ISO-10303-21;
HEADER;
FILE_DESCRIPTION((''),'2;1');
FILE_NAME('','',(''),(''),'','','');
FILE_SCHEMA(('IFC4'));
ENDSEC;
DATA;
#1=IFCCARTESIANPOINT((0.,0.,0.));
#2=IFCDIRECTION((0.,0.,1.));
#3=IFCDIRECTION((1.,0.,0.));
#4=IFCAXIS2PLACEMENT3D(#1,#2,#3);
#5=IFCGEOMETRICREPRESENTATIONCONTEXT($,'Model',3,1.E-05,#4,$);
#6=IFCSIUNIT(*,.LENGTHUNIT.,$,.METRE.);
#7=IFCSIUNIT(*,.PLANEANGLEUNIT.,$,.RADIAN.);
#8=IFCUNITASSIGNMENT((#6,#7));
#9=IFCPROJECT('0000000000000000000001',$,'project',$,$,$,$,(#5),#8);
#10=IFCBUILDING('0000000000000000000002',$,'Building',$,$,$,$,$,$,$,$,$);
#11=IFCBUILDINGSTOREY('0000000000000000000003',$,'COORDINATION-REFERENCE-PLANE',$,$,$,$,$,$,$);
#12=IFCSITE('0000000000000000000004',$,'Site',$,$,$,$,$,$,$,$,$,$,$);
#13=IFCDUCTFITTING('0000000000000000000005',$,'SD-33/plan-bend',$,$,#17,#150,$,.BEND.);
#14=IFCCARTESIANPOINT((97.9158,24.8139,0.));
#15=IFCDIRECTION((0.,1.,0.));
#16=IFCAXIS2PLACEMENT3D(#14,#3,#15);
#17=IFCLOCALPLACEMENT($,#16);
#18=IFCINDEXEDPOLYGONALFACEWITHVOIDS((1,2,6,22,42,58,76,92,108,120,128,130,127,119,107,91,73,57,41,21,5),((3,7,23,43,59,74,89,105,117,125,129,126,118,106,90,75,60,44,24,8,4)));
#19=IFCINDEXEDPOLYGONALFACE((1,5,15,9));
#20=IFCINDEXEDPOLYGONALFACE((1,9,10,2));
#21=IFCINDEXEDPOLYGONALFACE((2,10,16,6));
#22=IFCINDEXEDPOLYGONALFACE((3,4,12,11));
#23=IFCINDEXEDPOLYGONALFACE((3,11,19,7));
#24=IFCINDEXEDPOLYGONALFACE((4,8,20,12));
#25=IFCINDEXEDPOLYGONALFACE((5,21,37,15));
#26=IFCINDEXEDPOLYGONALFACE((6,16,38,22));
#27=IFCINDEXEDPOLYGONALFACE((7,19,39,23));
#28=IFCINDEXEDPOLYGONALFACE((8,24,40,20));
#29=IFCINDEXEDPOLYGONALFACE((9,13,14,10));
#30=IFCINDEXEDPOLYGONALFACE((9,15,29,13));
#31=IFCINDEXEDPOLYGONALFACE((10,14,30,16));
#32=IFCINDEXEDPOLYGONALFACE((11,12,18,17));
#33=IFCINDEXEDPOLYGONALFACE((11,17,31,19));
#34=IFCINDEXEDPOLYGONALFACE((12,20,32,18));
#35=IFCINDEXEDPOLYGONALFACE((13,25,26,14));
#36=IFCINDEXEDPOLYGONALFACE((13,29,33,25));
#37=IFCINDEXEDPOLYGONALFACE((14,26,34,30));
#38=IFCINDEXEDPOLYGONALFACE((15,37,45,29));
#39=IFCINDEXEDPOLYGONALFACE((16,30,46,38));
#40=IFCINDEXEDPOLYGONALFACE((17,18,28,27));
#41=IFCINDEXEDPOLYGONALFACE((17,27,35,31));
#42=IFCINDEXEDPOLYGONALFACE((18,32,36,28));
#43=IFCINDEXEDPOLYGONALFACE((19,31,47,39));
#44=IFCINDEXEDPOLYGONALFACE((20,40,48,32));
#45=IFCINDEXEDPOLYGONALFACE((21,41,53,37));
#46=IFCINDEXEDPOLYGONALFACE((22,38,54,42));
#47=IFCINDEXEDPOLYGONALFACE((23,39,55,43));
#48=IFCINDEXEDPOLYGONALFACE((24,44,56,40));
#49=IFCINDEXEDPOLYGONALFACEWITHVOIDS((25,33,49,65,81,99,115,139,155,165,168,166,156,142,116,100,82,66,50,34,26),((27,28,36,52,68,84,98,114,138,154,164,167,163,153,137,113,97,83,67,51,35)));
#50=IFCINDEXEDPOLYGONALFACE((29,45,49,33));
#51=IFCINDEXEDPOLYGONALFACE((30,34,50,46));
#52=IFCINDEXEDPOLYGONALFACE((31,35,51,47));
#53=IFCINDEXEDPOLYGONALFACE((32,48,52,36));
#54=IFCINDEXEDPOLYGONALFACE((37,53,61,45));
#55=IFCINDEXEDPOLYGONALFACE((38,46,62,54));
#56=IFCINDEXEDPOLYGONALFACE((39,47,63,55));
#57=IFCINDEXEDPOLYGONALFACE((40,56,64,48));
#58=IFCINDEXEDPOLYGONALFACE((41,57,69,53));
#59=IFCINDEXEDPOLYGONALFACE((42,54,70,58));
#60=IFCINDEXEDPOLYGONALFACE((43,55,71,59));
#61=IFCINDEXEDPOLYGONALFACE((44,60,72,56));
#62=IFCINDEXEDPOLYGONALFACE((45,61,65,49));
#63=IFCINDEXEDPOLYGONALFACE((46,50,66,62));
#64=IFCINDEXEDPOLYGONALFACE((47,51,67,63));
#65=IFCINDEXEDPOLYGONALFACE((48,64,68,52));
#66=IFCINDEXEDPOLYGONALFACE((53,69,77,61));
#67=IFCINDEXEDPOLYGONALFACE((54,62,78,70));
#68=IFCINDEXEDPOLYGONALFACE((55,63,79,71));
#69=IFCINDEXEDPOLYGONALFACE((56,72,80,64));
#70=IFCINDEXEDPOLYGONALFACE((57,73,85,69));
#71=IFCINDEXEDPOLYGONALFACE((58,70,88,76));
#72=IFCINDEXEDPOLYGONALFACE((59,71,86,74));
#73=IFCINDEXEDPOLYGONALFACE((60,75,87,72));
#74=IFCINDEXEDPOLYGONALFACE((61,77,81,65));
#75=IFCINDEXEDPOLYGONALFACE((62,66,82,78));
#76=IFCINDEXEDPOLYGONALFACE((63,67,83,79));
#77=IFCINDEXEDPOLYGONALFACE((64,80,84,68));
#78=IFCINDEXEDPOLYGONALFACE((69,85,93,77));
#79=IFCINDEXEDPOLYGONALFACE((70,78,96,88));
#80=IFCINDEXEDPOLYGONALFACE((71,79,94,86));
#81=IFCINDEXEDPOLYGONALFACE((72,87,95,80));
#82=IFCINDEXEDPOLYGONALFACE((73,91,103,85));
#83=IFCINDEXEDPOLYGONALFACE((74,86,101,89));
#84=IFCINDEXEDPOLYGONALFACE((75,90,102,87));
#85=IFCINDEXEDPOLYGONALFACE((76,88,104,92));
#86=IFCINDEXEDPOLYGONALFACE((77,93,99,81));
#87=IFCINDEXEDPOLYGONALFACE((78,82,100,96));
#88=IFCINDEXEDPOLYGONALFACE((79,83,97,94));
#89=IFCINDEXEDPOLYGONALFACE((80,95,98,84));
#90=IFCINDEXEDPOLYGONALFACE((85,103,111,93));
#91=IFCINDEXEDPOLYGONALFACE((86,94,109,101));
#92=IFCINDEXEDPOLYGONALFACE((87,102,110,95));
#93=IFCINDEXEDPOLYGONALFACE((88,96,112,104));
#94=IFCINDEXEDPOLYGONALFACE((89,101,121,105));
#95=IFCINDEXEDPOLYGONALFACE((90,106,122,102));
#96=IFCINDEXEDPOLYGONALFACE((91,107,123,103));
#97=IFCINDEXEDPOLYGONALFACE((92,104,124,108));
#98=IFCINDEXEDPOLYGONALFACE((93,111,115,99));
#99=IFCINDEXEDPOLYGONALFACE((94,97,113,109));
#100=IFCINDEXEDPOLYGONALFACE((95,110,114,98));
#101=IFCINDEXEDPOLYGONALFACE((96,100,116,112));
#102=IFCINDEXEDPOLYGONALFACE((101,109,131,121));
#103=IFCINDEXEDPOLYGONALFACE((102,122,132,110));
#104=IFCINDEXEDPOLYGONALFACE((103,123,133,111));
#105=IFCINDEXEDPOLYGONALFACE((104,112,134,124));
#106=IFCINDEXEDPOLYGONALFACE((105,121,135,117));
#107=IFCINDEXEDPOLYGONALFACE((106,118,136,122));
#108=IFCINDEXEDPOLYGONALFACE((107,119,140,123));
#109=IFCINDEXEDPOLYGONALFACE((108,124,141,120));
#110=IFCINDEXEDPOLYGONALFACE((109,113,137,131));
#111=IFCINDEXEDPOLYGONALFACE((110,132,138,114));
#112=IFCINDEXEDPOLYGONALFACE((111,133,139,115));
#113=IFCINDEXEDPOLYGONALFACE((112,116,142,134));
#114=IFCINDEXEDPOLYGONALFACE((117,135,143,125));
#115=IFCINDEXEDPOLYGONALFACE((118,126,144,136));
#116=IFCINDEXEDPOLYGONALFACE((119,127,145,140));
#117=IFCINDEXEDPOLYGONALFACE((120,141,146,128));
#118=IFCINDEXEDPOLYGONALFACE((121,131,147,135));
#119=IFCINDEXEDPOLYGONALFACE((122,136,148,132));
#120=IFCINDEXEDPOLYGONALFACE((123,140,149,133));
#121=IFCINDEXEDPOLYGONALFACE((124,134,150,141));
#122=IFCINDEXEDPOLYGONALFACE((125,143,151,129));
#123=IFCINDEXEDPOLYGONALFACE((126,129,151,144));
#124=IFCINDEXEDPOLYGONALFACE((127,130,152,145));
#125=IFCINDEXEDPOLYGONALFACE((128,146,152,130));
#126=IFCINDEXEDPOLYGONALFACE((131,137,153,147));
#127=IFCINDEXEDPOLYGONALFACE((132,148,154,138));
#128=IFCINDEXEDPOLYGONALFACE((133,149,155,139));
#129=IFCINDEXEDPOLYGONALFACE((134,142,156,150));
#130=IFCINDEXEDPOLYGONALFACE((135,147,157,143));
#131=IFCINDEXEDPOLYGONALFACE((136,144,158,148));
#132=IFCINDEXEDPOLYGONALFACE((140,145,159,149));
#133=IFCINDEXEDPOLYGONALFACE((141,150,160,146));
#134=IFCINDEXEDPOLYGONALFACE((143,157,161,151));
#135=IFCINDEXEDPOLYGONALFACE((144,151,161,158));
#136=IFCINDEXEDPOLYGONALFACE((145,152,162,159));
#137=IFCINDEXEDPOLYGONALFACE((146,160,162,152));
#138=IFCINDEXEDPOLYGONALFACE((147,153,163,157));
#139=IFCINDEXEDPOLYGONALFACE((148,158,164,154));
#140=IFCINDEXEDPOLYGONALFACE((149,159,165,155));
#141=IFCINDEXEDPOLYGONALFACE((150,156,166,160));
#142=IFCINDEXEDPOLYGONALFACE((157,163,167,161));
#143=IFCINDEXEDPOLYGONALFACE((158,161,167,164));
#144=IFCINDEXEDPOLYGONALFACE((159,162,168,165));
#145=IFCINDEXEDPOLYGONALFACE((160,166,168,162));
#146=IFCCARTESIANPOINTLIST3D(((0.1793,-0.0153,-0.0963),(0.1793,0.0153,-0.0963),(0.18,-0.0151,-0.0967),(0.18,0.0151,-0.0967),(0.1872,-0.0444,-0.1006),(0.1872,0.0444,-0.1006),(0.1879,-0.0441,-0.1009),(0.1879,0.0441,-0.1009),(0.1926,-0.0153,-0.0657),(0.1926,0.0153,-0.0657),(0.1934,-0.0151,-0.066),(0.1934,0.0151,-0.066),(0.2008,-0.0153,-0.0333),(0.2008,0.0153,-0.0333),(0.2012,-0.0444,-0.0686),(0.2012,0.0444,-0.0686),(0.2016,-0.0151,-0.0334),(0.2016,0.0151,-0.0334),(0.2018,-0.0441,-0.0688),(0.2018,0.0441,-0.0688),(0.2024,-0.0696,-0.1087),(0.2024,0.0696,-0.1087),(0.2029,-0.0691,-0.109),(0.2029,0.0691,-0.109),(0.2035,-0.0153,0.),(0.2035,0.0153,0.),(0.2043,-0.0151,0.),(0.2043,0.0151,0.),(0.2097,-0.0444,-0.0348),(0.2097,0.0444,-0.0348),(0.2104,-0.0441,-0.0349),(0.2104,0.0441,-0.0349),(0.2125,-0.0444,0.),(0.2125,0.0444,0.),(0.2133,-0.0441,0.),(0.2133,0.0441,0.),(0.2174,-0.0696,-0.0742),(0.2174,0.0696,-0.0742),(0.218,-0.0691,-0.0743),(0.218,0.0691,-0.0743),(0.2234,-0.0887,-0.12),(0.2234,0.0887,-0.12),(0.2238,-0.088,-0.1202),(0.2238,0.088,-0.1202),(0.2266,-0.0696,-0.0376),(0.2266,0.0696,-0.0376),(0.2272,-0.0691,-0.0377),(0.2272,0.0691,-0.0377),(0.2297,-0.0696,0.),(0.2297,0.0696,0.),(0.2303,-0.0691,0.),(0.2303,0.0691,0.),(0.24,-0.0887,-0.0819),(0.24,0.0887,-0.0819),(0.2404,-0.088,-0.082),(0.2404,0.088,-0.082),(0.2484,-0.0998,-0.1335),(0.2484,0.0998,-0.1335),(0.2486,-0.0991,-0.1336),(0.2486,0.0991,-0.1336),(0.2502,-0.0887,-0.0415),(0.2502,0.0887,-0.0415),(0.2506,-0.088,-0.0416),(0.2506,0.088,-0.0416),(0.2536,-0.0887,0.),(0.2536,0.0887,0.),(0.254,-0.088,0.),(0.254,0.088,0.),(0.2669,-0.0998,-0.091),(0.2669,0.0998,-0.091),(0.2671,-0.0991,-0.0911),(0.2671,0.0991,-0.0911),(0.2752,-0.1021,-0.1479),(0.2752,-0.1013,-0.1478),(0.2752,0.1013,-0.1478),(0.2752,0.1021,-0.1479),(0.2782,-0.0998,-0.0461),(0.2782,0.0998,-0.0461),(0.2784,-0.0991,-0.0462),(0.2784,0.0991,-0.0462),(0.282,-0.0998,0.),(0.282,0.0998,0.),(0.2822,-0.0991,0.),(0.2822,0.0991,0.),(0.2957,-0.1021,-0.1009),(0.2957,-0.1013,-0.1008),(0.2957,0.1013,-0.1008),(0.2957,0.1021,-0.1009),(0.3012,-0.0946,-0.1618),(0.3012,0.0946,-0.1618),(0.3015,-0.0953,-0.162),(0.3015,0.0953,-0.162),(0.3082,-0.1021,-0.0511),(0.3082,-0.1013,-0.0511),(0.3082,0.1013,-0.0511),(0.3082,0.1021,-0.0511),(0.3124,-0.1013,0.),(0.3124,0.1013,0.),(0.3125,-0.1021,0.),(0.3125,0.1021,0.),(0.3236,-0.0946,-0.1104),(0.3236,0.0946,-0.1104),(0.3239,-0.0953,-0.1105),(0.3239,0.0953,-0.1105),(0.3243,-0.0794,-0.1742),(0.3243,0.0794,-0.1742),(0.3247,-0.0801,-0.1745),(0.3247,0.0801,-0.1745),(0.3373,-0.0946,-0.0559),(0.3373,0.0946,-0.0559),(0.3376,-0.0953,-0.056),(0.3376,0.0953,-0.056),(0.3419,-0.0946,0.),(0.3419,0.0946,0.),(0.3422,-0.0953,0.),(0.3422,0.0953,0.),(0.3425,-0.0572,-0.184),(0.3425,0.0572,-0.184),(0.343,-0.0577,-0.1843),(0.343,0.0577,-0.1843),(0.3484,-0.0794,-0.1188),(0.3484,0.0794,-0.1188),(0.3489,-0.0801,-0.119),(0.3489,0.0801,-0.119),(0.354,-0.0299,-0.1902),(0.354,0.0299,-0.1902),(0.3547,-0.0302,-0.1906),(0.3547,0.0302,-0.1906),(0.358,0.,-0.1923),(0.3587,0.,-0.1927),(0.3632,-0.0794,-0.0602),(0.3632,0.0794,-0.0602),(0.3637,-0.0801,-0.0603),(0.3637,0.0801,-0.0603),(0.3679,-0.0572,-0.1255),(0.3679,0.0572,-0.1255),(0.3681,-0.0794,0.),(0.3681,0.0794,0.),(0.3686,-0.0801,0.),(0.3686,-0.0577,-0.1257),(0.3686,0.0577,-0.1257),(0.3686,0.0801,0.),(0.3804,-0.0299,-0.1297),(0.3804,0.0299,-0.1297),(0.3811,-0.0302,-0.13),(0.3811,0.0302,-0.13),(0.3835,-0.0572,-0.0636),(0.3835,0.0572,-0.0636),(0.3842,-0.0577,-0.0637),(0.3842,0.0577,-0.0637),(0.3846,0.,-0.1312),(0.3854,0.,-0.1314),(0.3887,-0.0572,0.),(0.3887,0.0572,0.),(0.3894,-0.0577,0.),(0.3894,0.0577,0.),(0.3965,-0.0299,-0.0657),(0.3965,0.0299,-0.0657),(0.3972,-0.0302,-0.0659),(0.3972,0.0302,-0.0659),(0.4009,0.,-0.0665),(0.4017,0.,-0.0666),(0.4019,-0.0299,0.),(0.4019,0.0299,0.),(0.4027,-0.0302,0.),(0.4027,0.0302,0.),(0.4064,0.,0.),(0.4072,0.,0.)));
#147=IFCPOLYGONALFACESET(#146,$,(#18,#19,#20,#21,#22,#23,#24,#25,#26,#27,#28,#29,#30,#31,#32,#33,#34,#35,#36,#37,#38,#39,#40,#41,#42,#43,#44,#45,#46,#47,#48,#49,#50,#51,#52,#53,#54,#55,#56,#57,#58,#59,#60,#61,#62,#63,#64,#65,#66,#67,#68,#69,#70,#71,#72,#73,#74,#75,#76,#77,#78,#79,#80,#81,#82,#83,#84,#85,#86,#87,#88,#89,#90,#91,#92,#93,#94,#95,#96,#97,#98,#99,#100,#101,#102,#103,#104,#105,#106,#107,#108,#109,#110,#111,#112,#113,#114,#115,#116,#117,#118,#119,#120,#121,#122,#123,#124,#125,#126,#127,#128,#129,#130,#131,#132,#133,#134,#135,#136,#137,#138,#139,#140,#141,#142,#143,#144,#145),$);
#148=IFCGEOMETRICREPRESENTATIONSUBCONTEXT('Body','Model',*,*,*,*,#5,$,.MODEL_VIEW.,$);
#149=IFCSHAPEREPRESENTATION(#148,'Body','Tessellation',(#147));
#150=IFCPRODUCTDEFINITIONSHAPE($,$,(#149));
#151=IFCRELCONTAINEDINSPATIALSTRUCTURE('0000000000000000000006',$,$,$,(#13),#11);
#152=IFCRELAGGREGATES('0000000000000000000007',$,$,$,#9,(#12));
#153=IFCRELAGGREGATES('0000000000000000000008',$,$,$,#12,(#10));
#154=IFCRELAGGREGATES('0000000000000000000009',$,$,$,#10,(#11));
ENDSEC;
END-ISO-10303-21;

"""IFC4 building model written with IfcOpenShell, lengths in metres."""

from ifc_helpers import new_model, entity, si_unit, frame, origin_with_axes, place, context, subcontext, project, spatial, element, save


model = new_model("IFC4")

# Units and contexts
model_context = context("Model", 3, precision=1e-05, world=origin_with_axes())
body_context_1 = subcontext(model_context, "Body", "Model", "MODEL_VIEW")
ifc_project = project(units=[si_unit("LENGTHUNIT", "METRE"), si_unit("PLANEANGLEUNIT", "RADIAN")], contexts=[model_context])

# Site, building, storey
site = spatial("IfcSite", under=ifc_project, Name="Site")
building = spatial("IfcBuilding", under=site, Name="Building")
storey = spatial("IfcBuildingStorey", under=building, Name="COORDINATION-REFERENCE-PLANE")

# Duct fitting
duct_fitting_1_placement = place(None, frame((97.9158, 24.8139, 0.0), z_axis=(1.0, 0.0, 0.0), x_axis=(0.0, 1.0, 0.0)))
element("IfcDuctFitting", 1, at=duct_fitting_1_placement, inside=storey, Name="SD-33/plan-bend", PredefinedType="BEND", context=body_context_1, shape_type="SweptSolid", body=[
    entity("IfcRevolvedAreaSolid", entity("IfcCircleHollowProfileDef", "AREA", None, entity("IfcAxis2Placement2D", entity("IfcCartesianPoint", [0.3048, 0.0])), 0.1024, 0.0008), entity("IfcAxis2Placement3D", entity("IfcCartesianPoint", [0.0, 0.0, 0.0]), entity("IfcDirection", [0.0, 0.0, 1.0]), entity("IfcDirection", [1.0, 0.0, 0.0])), entity("IfcAxis1Placement", entity("IfcCartesianPoint", [0.0, 0.0, 0.0]), entity("IfcDirection", [0.0, 1.0, 0.0])), 0.49301),
])

save(model, "model.ifc")
